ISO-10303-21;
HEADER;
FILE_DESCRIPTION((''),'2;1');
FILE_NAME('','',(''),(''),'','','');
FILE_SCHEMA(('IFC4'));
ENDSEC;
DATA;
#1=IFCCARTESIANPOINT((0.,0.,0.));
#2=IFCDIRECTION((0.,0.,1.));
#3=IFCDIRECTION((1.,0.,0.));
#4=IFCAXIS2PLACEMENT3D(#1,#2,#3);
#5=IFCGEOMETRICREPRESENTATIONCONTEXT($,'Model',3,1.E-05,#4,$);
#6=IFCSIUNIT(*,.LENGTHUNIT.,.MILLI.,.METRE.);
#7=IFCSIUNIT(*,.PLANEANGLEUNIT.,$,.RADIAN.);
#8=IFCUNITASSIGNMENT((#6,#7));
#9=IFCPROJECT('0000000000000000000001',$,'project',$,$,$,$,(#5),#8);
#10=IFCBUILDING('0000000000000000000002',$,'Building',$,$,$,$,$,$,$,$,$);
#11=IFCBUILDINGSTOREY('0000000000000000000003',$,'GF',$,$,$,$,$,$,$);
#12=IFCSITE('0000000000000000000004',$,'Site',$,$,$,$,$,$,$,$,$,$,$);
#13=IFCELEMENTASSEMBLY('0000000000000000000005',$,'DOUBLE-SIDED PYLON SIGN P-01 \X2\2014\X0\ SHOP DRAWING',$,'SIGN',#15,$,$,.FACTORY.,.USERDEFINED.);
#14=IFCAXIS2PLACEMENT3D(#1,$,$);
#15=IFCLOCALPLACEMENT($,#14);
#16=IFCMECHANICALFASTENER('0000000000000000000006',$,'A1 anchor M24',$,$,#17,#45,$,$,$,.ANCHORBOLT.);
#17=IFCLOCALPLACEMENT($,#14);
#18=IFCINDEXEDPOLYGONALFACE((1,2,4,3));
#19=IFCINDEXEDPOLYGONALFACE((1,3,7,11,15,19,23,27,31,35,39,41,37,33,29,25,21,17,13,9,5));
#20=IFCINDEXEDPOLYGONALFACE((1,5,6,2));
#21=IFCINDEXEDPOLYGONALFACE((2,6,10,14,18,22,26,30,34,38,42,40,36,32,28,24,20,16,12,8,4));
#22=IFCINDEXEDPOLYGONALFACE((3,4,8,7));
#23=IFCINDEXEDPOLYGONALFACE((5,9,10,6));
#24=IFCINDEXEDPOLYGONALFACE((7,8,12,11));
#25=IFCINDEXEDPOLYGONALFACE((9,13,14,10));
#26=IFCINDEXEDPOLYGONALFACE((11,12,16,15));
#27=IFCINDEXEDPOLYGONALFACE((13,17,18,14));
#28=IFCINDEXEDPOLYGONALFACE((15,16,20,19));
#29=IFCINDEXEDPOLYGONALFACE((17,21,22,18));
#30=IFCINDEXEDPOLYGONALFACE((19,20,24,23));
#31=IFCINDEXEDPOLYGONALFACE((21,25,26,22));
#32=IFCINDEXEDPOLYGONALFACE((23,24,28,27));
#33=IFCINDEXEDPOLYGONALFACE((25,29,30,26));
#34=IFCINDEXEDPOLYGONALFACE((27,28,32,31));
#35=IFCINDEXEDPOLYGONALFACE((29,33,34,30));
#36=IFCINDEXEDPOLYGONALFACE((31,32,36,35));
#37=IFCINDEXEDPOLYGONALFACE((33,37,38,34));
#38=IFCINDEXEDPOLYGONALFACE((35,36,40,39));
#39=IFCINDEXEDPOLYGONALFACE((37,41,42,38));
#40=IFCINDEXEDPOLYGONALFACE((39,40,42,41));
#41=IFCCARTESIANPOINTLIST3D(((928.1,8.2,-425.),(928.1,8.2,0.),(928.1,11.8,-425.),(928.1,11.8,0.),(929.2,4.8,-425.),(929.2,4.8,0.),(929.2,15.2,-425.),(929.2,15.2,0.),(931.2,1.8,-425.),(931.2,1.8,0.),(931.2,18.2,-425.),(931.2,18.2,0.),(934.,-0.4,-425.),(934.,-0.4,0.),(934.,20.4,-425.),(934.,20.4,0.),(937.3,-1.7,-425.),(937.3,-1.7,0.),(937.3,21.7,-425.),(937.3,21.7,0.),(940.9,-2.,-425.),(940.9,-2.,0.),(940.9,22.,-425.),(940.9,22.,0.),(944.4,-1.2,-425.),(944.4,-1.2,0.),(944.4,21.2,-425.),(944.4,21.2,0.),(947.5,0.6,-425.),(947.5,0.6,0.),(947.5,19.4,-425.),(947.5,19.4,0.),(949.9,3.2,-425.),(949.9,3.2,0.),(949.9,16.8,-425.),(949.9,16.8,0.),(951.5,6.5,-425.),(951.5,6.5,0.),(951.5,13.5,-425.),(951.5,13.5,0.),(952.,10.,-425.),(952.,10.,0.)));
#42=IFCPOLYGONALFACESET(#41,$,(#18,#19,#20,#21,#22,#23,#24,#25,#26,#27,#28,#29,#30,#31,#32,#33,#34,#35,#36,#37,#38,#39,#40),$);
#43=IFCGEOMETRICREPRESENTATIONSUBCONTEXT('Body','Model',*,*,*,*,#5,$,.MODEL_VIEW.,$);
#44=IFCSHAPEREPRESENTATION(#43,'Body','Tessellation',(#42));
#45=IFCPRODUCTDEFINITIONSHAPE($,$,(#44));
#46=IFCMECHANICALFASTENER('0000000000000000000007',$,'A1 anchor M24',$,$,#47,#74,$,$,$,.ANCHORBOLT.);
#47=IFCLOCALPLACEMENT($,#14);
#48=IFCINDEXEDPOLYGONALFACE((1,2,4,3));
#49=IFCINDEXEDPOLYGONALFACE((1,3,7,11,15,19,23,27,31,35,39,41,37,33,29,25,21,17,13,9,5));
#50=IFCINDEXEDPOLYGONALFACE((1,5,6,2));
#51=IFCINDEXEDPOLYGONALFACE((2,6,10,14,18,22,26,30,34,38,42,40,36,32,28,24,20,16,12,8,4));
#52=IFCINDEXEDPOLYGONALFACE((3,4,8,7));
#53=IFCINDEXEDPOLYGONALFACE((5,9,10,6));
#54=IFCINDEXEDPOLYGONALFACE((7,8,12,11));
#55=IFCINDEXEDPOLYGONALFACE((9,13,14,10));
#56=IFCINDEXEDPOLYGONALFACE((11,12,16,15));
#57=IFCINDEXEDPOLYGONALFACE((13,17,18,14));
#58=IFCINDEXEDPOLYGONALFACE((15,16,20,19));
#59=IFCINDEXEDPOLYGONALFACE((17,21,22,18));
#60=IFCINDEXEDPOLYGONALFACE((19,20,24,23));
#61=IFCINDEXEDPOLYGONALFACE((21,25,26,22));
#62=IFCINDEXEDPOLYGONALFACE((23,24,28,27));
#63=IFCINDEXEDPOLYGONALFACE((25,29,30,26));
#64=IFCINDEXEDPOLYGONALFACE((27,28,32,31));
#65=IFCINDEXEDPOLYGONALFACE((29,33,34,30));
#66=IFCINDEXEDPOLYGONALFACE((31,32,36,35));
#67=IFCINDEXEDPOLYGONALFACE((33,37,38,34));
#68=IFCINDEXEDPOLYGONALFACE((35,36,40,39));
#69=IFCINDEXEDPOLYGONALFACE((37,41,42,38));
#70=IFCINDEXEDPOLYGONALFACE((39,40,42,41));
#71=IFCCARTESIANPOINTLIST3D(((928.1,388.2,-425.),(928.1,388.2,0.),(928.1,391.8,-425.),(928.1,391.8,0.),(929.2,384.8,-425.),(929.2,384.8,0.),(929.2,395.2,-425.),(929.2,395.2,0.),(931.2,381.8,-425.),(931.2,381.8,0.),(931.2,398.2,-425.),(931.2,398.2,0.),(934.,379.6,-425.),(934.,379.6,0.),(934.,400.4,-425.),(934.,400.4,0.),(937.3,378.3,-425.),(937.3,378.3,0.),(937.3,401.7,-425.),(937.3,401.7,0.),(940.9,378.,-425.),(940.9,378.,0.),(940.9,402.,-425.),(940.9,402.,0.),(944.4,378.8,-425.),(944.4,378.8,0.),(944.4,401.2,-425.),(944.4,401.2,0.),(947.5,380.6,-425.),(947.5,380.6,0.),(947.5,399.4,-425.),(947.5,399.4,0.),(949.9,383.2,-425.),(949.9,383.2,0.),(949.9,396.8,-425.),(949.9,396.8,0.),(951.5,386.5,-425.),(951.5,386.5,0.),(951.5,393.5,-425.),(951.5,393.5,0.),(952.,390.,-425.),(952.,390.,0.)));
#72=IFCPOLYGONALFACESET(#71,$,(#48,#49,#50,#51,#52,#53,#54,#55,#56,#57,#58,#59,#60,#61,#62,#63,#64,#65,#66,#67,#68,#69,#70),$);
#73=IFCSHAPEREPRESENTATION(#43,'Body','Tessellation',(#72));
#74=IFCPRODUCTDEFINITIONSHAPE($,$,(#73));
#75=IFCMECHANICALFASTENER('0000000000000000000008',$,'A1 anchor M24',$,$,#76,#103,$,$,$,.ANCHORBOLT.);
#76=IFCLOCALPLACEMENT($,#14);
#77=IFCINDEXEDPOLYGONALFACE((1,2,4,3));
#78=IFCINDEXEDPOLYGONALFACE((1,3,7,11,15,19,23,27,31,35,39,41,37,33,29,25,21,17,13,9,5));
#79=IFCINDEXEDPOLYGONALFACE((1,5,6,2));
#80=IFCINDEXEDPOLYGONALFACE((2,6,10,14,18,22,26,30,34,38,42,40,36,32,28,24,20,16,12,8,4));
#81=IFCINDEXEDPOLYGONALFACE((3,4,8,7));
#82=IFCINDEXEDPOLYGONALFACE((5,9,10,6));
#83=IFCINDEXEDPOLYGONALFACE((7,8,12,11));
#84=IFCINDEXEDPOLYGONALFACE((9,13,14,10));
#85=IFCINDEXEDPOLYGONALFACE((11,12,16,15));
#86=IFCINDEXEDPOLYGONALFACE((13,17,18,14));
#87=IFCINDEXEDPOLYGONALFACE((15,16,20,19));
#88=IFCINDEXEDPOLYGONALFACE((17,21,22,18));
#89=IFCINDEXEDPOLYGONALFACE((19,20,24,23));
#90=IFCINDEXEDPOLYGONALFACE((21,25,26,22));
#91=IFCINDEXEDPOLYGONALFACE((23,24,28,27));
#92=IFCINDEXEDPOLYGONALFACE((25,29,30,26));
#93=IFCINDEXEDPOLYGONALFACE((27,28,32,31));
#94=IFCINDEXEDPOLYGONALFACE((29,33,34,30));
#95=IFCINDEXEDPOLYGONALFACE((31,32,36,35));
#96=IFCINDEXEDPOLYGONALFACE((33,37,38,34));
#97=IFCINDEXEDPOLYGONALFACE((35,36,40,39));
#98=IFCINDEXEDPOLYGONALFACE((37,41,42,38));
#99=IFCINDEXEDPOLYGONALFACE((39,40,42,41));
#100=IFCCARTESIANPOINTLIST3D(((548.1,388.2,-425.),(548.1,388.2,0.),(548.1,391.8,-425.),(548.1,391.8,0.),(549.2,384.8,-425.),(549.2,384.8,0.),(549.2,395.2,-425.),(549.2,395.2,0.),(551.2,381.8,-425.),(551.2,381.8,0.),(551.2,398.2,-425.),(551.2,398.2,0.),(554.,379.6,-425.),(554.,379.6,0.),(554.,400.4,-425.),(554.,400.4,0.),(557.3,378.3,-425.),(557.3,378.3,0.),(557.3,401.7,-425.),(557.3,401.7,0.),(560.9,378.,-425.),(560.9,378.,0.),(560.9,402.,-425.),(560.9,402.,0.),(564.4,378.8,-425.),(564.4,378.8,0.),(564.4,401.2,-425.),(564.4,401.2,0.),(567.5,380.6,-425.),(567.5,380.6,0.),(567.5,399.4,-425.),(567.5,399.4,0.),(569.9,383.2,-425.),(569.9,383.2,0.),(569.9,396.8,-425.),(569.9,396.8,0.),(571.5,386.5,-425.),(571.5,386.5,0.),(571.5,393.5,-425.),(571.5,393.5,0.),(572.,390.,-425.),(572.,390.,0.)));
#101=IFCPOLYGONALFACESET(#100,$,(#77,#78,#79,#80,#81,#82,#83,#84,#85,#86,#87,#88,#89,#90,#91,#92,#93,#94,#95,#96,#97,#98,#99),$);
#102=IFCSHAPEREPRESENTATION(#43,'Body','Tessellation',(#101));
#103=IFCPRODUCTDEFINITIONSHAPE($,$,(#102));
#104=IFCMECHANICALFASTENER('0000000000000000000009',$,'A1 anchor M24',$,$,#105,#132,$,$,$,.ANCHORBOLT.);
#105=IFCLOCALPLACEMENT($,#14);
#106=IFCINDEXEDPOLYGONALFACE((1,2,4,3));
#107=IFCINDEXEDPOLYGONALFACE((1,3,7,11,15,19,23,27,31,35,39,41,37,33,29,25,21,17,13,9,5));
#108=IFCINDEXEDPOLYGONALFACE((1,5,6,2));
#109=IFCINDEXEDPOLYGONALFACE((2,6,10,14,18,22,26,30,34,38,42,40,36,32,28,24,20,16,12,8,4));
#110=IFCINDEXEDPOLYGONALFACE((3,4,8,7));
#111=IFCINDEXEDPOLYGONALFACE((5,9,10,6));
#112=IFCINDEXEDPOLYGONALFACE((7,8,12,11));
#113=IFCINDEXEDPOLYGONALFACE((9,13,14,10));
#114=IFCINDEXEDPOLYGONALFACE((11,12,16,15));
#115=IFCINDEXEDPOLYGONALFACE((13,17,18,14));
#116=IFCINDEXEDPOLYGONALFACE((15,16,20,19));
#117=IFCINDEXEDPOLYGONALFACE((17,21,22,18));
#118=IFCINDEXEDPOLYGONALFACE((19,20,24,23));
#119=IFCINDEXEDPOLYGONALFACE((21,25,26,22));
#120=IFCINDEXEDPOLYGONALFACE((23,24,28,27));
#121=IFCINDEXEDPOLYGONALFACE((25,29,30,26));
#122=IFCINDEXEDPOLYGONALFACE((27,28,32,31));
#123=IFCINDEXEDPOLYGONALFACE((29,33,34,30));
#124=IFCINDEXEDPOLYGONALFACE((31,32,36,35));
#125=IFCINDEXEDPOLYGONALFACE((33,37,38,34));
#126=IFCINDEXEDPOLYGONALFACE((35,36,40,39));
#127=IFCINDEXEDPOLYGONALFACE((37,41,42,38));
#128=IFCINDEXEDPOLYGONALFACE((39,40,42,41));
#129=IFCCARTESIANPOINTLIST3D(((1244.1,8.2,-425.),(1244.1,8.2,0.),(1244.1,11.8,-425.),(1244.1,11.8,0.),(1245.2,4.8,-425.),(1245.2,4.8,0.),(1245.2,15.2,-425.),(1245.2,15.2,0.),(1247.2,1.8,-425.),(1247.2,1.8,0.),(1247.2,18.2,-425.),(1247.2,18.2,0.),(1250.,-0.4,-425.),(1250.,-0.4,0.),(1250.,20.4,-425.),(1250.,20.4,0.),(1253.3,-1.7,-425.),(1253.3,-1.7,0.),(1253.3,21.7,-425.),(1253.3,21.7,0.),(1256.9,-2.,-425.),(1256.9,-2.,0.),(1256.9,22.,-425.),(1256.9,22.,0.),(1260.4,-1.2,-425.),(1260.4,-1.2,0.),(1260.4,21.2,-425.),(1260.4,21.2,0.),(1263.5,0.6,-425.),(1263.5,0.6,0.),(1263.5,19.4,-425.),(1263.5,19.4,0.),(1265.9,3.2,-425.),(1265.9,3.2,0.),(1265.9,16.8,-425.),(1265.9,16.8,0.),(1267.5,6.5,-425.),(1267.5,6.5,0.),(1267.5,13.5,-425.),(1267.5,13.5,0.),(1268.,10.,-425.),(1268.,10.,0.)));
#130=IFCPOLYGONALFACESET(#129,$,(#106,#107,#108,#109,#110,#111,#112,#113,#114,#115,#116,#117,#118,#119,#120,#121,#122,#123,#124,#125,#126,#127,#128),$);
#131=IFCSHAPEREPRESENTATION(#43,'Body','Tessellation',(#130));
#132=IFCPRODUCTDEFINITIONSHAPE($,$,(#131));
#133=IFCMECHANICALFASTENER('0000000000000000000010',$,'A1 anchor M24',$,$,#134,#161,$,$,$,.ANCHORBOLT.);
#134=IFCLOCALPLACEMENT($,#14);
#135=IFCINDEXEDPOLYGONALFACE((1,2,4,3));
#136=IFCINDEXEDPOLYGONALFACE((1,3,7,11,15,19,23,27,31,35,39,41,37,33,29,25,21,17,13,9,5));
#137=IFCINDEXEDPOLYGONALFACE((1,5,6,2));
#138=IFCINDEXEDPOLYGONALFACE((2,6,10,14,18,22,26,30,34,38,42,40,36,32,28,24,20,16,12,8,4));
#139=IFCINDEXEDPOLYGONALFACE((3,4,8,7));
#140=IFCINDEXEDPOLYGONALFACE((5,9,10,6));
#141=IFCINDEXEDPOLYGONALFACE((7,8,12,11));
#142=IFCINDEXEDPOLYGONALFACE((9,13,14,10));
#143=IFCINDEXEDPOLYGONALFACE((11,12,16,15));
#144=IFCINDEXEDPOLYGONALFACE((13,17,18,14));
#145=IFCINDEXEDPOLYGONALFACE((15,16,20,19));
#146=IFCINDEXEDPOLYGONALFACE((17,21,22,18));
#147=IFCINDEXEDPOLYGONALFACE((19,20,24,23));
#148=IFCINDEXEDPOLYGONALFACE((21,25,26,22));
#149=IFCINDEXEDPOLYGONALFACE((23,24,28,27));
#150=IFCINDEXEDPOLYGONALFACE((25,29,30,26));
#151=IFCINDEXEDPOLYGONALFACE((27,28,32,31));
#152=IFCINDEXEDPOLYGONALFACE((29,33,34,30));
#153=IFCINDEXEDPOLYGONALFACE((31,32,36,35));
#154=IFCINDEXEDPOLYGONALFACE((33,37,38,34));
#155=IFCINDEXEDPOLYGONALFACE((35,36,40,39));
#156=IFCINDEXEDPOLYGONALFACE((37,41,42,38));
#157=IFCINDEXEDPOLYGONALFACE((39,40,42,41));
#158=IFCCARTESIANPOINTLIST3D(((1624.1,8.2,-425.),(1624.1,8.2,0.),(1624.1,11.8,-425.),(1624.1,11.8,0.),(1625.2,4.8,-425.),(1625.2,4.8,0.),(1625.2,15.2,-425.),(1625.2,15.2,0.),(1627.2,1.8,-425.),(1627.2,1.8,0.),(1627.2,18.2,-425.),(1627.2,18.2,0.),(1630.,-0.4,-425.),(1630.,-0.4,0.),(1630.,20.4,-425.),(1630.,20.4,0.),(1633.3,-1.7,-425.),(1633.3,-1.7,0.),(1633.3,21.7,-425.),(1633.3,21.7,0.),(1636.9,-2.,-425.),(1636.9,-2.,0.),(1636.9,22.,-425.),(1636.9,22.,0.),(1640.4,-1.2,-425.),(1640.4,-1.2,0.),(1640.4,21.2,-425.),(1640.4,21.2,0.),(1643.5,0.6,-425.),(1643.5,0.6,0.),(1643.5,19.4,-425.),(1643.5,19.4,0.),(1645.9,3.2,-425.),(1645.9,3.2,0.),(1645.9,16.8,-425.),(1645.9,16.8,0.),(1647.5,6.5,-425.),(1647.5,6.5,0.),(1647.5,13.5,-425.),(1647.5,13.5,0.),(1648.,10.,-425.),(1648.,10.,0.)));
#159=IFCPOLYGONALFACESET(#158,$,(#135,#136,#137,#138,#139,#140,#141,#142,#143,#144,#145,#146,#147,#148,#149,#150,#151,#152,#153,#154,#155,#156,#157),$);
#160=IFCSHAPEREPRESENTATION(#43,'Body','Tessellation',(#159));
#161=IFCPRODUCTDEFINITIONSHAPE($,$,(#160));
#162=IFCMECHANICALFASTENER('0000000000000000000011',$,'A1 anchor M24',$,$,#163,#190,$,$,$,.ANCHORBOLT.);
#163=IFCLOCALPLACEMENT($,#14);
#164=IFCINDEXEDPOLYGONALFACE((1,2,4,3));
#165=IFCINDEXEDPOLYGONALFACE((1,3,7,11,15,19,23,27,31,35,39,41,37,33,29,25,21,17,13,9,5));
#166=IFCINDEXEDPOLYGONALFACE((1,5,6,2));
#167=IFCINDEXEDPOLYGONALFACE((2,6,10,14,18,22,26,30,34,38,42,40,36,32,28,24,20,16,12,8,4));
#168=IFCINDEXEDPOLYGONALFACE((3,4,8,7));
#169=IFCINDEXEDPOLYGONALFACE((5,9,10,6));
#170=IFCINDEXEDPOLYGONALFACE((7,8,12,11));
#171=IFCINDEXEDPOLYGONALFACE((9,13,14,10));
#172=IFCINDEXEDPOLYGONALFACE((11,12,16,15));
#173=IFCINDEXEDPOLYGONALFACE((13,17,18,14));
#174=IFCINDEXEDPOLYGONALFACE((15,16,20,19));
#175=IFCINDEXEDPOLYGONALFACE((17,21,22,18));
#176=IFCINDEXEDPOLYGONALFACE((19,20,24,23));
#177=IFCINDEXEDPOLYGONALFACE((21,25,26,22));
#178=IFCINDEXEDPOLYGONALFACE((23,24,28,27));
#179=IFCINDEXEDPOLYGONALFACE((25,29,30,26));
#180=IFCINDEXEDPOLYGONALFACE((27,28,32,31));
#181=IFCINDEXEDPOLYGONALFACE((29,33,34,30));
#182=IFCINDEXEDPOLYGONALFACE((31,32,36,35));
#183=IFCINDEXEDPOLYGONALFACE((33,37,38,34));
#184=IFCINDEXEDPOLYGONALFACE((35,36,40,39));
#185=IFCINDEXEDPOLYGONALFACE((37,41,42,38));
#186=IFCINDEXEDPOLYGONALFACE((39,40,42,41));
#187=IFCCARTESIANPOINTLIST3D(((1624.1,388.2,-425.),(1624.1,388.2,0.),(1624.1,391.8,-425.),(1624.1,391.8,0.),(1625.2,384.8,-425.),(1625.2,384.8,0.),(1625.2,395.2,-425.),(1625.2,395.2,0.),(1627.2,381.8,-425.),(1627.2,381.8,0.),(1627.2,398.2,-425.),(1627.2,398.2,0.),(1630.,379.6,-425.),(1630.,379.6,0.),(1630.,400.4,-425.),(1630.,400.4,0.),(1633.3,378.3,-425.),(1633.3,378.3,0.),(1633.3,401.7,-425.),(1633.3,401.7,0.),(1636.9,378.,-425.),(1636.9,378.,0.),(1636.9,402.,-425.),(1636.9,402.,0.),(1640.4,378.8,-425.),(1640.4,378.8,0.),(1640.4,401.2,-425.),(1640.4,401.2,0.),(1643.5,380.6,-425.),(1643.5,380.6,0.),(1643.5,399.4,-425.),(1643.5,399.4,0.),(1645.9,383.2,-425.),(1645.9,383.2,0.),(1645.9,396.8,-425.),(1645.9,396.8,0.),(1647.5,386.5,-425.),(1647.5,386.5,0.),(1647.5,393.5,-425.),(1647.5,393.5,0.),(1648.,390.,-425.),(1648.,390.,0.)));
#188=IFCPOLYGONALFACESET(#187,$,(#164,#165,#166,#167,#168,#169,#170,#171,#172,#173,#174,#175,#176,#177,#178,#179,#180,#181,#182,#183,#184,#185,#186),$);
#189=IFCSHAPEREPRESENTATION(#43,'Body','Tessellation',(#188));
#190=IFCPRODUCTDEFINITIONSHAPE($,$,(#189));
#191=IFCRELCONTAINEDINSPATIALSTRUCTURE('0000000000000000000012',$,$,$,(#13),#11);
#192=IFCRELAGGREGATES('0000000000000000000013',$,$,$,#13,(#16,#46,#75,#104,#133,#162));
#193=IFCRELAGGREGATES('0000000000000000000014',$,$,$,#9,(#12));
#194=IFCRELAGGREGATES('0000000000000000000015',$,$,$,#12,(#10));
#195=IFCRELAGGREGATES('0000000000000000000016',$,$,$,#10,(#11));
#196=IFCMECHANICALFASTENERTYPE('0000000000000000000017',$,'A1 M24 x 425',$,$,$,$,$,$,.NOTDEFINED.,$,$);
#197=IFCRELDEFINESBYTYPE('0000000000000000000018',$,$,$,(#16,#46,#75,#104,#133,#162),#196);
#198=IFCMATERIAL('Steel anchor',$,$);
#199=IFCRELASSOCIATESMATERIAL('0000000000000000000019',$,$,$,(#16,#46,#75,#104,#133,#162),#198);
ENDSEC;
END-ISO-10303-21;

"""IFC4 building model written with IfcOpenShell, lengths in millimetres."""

from ifc_helpers import new_model, si_unit, frame, origin, origin_with_axes, place, context, subcontext, project, spatial, circle, extrude, material, type_object, element, aggregate, save


model = new_model("IFC4")

# Units and contexts
model_context = context("Model", 3, precision=1e-05, world=origin_with_axes())
body_context = subcontext(model_context, "Body", "Model", "MODEL_VIEW")
ifc_project = project(units=[si_unit("LENGTHUNIT", "METRE", prefix="MILLI"), si_unit("PLANEANGLEUNIT", "RADIAN")], contexts=[model_context])

# Site, building, storey
site = spatial("IfcSite", under=ifc_project, Name="Site")
building = spatial("IfcBuilding", under=site, Name="Building")
storey = spatial("IfcBuildingStorey", under=building, Name="GF")

# Element assembly, mechanical fasteners
assembly_placement = place(None, origin_with_axes())
assembly = element("IfcElementAssembly", 1, at=assembly_placement, inside=storey, Name="DOUBLE-SIDED PYLON SIGN P-01 — SHOP DRAWING", ObjectType="SIGN", AssemblyPlace="FACTORY", PredefinedType="USERDEFINED")
ifc_material_1 = material(Name="Steel anchor")
mechanical_fastener_type = type_object("IfcMechanicalFastenerType", Name="A1 M24 x 425", PredefinedType="NOTDEFINED")
mechanical_fastener_1_placement = place(assembly_placement, frame((940.0, 10.0, -425.0), z_axis=(0.0, 0.0, 1.0), x_axis=(1.0, 0.0, 0.0)))
mechanical_fastener_1 = element("IfcMechanicalFastener", 2, at=mechanical_fastener_1_placement, type_object=mechanical_fastener_type, material=ifc_material_1, Name="A1 anchor M24", PredefinedType="ANCHORBOLT", context=body_context, shape_type="SweptSolid", body=[
    extrude(circle(Radius=12.0), origin(), (0.0, 0.0, 1.0), 425.0),
])
mechanical_fastener_2_placement = place(assembly_placement, frame((940.0, 390.0, -425.0), z_axis=(0.0, 0.0, 1.0), x_axis=(1.0, 0.0, 0.0)))
mechanical_fastener_2 = element("IfcMechanicalFastener", 3, at=mechanical_fastener_2_placement, type_object=mechanical_fastener_type, material=ifc_material_1, Name="A1 anchor M24", PredefinedType="ANCHORBOLT", context=body_context, shape_type="SweptSolid", body=[
    extrude(circle(Radius=12.0), origin(), (0.0, 0.0, 1.0), 425.0),
])
mechanical_fastener_3_placement = place(assembly_placement, frame((560.0, 390.0, -425.0), z_axis=(0.0, 0.0, 1.0), x_axis=(1.0, 0.0, 0.0)))
mechanical_fastener_3 = element("IfcMechanicalFastener", 4, at=mechanical_fastener_3_placement, type_object=mechanical_fastener_type, material=ifc_material_1, Name="A1 anchor M24", PredefinedType="ANCHORBOLT", context=body_context, shape_type="SweptSolid", body=[
    extrude(circle(Radius=12.0), origin(), (0.0, 0.0, 1.0), 425.0),
])
mechanical_fastener_4_placement = place(assembly_placement, frame((1256.0, 10.0, -425.0), z_axis=(0.0, 0.0, 1.0), x_axis=(1.0, 0.0, 0.0)))
mechanical_fastener_4 = element("IfcMechanicalFastener", 5, at=mechanical_fastener_4_placement, type_object=mechanical_fastener_type, material=ifc_material_1, Name="A1 anchor M24", PredefinedType="ANCHORBOLT", context=body_context, shape_type="SweptSolid", body=[
    extrude(circle(Radius=12.0), origin(), (0.0, 0.0, 1.0), 425.0),
])
mechanical_fastener_5_placement = place(assembly_placement, frame((1636.0, 10.0, -425.0), z_axis=(0.0, 0.0, 1.0), x_axis=(1.0, 0.0, 0.0)))
mechanical_fastener_5 = element("IfcMechanicalFastener", 6, at=mechanical_fastener_5_placement, type_object=mechanical_fastener_type, material=ifc_material_1, Name="A1 anchor M24", PredefinedType="ANCHORBOLT", context=body_context, shape_type="SweptSolid", body=[
    extrude(circle(Radius=12.0), origin(), (0.0, 0.0, 1.0), 425.0),
])
mechanical_fastener_6_placement = place(assembly_placement, frame((1636.0, 390.0, -425.0), z_axis=(0.0, 0.0, 1.0), x_axis=(1.0, 0.0, 0.0)))
mechanical_fastener_6 = element("IfcMechanicalFastener", 7, at=mechanical_fastener_6_placement, type_object=mechanical_fastener_type, material=ifc_material_1, Name="A1 anchor M24", PredefinedType="ANCHORBOLT", context=body_context, shape_type="SweptSolid", body=[
    extrude(circle(Radius=12.0), origin(), (0.0, 0.0, 1.0), 425.0),
])
aggregate(assembly, [mechanical_fastener_1, mechanical_fastener_2, mechanical_fastener_3, mechanical_fastener_4, mechanical_fastener_5, mechanical_fastener_6])

save(model, "model.ifc")
